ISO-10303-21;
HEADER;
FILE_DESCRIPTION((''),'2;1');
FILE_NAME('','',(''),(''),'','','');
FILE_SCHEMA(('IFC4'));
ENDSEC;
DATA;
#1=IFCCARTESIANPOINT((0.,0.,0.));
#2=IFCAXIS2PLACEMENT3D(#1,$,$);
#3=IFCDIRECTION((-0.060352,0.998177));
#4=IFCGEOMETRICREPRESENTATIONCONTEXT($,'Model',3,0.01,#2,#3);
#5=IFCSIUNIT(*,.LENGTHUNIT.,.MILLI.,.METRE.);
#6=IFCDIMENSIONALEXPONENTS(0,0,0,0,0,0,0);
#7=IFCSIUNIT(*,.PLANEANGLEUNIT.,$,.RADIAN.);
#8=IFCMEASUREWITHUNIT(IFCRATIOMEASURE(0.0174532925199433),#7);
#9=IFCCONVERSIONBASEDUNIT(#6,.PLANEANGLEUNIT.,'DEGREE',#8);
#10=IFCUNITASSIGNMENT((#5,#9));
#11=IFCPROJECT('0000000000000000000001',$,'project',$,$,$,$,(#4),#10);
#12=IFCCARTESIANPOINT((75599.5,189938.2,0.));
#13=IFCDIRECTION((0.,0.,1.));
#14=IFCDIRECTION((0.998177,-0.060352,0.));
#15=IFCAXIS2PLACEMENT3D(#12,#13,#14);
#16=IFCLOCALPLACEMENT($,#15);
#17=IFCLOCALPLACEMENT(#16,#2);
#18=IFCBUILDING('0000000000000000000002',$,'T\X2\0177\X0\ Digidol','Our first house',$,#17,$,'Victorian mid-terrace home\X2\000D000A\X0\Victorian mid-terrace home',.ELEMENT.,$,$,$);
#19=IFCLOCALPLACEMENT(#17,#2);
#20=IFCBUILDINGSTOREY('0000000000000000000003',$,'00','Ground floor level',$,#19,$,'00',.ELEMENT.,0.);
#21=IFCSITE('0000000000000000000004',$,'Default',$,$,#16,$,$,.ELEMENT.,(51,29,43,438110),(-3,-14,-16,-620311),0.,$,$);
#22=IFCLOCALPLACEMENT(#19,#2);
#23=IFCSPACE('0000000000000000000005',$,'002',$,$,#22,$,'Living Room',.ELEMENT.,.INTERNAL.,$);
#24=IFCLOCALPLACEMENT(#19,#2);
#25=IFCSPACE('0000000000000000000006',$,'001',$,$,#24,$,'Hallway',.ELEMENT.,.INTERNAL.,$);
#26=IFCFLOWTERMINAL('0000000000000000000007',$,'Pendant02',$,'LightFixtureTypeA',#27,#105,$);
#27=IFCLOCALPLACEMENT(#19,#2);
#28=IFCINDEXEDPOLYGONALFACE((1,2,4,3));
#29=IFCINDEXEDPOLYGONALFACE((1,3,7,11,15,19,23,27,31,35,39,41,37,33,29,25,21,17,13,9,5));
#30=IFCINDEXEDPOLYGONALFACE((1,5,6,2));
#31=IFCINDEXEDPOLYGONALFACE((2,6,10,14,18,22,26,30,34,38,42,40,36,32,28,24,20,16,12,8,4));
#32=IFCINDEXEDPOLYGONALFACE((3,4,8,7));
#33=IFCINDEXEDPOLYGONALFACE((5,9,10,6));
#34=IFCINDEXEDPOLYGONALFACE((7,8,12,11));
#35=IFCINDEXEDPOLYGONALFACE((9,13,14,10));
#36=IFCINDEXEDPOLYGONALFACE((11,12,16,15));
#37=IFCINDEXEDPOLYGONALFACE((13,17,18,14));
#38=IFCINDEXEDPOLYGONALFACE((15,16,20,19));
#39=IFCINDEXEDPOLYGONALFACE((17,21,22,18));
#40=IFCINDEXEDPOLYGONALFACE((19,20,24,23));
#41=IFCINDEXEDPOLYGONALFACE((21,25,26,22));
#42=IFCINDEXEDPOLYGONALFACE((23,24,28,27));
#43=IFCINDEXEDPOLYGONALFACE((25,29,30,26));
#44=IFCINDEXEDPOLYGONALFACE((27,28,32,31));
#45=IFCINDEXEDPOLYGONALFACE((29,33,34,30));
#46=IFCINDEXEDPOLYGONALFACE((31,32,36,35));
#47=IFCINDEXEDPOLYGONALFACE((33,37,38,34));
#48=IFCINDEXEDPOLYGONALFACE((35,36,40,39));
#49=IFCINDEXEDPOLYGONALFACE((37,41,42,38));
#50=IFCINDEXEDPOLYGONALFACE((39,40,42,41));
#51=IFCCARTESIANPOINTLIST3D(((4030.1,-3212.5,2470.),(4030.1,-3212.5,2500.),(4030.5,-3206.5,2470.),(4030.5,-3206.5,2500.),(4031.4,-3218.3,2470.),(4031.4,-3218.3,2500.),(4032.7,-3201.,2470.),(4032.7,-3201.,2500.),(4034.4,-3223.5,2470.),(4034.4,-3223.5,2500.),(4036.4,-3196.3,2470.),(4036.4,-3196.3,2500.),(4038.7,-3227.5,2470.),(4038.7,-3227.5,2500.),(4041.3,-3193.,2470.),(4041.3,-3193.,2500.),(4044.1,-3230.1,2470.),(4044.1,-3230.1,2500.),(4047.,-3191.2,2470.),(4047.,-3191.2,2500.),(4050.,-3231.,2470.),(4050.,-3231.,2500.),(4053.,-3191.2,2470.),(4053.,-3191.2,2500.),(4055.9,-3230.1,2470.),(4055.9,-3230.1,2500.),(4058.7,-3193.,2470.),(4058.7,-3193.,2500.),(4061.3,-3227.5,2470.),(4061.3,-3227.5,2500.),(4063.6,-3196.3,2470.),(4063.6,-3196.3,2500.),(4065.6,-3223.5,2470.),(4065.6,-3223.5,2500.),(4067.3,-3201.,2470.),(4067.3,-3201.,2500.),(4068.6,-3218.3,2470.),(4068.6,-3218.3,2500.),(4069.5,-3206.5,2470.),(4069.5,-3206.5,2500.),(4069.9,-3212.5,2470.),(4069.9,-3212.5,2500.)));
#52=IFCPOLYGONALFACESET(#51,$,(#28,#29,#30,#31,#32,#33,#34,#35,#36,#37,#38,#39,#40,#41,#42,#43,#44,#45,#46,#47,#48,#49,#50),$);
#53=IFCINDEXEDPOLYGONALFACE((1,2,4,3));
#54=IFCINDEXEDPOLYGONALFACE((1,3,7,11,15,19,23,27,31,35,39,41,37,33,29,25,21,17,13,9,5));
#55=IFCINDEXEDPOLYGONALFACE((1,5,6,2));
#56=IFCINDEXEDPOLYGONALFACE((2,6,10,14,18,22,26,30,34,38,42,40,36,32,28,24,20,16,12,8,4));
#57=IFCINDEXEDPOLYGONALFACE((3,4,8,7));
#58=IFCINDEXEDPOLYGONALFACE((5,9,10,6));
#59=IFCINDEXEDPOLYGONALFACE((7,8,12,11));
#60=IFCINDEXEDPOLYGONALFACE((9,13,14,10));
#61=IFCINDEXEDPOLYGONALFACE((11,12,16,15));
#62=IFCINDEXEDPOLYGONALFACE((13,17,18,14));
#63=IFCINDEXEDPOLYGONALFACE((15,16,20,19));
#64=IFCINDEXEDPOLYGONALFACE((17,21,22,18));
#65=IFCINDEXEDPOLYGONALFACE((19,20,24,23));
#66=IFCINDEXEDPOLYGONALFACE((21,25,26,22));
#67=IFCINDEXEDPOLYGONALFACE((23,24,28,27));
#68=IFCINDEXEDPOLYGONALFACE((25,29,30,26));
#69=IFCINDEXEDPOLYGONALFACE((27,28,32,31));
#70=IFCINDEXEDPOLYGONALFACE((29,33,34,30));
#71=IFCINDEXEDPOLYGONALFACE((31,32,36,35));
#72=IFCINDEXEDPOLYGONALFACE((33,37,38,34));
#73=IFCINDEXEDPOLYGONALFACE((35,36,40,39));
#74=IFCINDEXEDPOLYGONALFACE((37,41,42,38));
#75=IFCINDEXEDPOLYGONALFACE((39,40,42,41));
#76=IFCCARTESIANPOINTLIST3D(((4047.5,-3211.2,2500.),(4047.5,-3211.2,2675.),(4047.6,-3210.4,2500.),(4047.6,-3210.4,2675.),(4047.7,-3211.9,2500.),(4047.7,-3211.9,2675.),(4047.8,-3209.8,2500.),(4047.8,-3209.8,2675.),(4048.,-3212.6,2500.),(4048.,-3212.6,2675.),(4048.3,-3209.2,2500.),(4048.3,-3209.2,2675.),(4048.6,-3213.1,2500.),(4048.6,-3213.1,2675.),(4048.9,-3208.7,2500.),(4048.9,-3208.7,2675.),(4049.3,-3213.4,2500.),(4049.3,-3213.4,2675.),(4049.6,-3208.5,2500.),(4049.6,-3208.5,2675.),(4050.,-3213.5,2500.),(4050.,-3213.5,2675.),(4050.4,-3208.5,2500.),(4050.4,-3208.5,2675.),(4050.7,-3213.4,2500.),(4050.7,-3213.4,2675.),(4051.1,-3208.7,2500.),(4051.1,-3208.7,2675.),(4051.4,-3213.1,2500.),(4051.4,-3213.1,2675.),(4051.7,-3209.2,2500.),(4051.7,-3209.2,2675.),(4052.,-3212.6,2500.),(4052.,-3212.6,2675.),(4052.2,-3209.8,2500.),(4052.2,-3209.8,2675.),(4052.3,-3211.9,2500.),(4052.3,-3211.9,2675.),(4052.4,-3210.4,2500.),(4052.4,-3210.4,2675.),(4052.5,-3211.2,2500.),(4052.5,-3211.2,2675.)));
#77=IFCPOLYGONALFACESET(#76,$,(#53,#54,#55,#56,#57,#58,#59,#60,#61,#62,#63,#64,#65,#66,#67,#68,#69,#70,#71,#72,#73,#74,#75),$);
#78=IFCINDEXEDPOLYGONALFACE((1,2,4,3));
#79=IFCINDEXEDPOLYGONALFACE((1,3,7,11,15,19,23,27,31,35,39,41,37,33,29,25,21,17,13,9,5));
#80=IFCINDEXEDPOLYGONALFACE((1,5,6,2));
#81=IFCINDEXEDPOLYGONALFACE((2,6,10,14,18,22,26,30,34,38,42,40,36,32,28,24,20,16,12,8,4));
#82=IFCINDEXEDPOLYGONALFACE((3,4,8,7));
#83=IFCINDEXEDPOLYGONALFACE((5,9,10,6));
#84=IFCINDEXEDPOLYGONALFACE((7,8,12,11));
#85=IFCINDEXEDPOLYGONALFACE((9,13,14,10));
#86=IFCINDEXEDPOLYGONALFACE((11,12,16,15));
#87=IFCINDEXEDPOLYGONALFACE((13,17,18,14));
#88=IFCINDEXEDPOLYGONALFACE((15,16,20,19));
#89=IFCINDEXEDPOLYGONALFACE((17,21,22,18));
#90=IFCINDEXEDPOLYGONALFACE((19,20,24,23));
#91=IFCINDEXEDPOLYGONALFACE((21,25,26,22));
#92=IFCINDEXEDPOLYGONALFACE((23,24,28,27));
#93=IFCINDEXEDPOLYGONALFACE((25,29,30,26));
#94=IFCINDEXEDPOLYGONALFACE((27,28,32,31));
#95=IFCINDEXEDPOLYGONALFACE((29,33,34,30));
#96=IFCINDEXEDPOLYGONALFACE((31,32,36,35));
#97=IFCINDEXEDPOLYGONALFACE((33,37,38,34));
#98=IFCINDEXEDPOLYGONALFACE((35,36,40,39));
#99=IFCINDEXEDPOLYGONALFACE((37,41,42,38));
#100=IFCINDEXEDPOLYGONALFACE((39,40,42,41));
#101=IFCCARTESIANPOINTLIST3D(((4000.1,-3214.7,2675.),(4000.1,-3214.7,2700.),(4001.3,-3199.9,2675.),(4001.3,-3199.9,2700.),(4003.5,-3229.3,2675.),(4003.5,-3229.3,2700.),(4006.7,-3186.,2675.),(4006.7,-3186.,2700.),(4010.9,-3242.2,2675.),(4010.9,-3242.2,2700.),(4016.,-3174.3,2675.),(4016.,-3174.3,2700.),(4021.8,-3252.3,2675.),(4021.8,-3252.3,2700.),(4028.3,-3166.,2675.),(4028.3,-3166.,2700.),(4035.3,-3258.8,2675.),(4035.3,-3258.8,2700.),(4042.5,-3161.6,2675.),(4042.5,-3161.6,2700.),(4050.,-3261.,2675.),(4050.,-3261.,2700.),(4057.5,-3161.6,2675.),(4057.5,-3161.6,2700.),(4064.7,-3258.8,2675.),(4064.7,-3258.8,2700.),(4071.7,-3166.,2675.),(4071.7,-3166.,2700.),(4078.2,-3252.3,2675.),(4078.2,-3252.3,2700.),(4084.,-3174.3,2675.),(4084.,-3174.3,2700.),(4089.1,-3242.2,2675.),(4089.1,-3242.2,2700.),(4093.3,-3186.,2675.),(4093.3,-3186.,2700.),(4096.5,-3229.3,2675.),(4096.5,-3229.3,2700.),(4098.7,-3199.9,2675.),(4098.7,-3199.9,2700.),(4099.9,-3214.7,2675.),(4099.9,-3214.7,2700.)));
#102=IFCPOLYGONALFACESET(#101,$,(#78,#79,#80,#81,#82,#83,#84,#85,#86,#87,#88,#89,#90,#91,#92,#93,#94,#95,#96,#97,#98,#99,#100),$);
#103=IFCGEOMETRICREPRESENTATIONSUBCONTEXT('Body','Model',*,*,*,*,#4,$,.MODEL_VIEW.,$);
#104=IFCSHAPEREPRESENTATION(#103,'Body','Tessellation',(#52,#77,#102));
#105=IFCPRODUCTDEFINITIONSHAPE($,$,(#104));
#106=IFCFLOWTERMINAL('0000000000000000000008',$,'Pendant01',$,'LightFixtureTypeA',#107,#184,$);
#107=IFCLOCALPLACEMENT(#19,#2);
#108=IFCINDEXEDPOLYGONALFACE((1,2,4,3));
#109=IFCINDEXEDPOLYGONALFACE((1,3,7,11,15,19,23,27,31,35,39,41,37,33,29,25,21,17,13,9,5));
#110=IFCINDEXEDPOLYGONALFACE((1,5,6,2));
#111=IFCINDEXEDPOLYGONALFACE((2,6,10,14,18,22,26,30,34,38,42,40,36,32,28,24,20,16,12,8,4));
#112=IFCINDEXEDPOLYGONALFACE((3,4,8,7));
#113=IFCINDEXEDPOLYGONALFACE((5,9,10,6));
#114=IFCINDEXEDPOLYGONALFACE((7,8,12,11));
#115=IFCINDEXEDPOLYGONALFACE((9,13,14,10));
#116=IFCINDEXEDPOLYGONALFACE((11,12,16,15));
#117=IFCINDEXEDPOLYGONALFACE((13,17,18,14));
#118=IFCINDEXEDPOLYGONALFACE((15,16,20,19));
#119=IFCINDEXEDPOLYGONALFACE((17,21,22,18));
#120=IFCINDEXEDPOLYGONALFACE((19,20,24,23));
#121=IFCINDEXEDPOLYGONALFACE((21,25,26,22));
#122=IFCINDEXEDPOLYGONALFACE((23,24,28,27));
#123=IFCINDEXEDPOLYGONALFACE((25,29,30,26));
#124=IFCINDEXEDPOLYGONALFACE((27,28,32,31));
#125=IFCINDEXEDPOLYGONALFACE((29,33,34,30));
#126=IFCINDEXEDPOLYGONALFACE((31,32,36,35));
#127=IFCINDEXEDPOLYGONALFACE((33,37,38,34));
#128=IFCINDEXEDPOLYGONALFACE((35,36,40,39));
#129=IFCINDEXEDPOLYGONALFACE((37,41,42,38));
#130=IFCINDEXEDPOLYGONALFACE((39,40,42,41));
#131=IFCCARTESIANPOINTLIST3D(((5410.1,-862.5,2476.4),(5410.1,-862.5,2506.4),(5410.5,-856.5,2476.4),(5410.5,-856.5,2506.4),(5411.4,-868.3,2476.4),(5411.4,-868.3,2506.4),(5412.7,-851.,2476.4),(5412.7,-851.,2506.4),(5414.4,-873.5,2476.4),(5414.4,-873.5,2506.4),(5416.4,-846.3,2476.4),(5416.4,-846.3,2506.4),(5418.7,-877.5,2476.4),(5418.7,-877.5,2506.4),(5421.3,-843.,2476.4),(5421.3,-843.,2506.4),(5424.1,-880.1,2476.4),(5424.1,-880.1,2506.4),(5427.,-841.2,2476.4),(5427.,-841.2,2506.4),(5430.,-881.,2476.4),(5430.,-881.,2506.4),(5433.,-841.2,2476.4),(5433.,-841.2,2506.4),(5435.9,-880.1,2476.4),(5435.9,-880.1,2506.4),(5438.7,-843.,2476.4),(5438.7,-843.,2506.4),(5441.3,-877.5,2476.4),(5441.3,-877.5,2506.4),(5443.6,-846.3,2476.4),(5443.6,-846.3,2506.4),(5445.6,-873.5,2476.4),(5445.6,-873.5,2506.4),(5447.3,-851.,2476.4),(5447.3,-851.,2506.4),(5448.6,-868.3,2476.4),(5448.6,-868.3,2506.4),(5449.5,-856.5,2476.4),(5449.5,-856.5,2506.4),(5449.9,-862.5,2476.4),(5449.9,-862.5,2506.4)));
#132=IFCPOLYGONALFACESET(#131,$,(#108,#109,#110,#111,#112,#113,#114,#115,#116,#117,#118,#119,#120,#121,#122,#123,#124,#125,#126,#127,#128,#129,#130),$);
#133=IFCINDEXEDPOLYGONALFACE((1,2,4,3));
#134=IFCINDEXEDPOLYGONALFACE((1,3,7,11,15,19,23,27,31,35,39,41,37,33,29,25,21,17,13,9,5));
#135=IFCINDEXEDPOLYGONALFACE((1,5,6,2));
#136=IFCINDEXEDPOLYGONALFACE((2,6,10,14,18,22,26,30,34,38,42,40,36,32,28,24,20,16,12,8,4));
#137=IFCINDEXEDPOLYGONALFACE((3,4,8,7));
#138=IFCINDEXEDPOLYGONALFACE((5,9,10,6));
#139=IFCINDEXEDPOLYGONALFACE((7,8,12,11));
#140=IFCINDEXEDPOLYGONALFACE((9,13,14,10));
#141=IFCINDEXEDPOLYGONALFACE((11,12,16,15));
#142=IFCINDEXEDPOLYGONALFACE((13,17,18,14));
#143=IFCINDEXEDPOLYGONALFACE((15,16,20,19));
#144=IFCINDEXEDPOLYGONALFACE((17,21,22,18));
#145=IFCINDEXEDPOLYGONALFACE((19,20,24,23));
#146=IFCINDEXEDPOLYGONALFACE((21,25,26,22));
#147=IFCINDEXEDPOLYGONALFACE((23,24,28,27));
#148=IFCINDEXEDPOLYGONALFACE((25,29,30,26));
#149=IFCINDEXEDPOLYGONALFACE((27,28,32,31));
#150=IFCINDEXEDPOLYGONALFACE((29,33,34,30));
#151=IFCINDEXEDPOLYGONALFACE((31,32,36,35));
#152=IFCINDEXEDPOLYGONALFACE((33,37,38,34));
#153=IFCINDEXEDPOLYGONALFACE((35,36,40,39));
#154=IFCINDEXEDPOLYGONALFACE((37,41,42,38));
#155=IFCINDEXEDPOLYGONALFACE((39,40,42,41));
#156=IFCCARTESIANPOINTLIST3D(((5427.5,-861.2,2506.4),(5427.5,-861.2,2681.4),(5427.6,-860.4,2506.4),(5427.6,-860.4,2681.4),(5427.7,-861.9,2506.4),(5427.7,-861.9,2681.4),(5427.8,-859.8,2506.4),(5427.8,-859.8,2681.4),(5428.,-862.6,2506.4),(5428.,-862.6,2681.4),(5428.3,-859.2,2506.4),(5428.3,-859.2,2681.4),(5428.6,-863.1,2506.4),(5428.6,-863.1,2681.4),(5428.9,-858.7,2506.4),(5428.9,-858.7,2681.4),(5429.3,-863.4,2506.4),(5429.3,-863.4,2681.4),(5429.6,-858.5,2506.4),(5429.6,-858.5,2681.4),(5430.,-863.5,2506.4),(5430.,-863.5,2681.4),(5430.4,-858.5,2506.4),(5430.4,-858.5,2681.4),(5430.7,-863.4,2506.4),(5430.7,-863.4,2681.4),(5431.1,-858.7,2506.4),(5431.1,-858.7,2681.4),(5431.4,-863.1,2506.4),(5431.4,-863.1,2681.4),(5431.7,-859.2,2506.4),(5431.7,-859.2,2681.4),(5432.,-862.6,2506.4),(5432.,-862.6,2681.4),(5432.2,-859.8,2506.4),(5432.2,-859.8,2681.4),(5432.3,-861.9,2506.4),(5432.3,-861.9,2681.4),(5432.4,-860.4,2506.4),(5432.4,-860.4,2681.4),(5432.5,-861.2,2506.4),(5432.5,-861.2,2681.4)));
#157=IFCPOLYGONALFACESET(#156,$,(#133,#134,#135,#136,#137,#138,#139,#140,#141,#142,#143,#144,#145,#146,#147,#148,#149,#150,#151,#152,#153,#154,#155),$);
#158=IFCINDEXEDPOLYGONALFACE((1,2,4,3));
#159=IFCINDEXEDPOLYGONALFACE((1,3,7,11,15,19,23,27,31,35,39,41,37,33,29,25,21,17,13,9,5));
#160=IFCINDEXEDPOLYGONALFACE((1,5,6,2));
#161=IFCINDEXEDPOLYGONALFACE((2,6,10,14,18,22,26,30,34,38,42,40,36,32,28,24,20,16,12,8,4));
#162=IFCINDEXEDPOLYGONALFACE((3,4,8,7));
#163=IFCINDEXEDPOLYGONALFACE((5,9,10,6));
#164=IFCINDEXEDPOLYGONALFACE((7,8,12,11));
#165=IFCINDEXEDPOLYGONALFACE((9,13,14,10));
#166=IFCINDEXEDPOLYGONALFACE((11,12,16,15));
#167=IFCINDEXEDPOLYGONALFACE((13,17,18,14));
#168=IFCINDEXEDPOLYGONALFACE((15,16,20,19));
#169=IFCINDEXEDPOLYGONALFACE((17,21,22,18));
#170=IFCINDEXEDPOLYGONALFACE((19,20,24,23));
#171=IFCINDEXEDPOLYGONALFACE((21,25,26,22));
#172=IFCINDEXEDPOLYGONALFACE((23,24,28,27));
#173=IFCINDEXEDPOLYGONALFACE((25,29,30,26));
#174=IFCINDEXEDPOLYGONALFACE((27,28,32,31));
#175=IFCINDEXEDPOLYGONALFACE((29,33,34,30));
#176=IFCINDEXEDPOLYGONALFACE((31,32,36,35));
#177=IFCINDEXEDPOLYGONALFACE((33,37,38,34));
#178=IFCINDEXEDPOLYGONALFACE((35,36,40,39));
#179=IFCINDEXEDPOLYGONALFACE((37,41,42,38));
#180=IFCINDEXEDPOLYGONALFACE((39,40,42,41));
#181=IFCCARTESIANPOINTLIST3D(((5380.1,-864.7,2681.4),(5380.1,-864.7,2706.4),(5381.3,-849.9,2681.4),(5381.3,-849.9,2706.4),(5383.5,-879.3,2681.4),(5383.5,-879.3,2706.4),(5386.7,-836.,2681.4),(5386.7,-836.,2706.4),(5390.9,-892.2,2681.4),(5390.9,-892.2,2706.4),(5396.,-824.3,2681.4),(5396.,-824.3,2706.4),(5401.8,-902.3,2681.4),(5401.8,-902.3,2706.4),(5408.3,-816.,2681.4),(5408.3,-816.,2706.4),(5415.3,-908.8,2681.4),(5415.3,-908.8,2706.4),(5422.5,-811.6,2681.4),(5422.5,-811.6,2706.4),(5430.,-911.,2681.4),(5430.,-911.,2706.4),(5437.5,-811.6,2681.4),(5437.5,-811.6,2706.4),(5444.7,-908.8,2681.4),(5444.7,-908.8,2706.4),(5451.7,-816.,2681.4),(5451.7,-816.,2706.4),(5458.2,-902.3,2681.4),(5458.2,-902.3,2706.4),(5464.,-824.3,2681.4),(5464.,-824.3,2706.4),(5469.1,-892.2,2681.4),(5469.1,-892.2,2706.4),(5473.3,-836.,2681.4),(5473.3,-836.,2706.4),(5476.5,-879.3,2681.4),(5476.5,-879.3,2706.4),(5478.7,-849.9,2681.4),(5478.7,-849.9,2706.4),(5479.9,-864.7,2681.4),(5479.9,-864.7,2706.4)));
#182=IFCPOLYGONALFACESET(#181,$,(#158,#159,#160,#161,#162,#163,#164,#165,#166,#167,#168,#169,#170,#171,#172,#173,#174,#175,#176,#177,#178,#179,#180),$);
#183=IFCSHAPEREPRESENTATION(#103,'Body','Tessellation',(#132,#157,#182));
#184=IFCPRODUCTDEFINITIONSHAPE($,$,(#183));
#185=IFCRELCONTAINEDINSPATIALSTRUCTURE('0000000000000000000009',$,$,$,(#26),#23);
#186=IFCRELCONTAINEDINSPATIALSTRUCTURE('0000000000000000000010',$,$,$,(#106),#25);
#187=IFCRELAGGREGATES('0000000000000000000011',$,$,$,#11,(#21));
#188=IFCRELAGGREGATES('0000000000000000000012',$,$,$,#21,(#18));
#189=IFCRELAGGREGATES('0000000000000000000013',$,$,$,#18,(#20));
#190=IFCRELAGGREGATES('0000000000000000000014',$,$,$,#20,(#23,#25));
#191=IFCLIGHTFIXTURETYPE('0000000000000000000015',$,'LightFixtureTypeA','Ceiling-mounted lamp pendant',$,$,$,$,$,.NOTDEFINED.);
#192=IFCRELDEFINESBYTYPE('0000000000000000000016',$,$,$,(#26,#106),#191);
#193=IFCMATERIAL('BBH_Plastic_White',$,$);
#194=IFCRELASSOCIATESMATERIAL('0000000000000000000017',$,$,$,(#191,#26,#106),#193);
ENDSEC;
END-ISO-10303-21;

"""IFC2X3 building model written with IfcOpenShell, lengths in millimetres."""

from ifc_helpers import new_model, entity, si_unit, converted_unit, direction, frame, frame_2d, origin, place, context, subcontext, project, spatial, circle, extrude, source, transform, mapped, material, type_object, type_shapes, element, save


model = new_model("IFC2X3")

# Units and contexts
model_context = context("Model", 3, precision=0.01, world=origin(), true_north=direction((-0.060352, 0.998177)))
body_context = subcontext(model_context, "Body", "Model", "MODEL_VIEW")
ifc_project = project(units=[si_unit("LENGTHUNIT", "METRE", prefix="MILLI"), converted_unit("PLANEANGLEUNIT", "DEGREE", entity("IfcRatioMeasure", 0.0174532925199433), si_unit("PLANEANGLEUNIT", "RADIAN"), dimensions=[0, 0, 0, 0, 0, 0, 0])], contexts=[model_context])

# Site, building, storey
site_placement = place(None, frame((75599.5, 189938.2, 0.0), z_axis=(0.0, 0.0, 1.0), x_axis=(0.998177, -0.060352, 0.0)))
site = spatial("IfcSite", under=ifc_project, at=site_placement, Name="Default", CompositionType="ELEMENT", RefLatitude=(51, 29, 43, 438110), RefLongitude=(-3, -14, -16, -620311), RefElevation=0.0)
building_placement = place(site_placement, origin())
building = spatial("IfcBuilding", under=site, at=building_placement, Name="Tŷ Digidol", Description="Our first house", LongName="Victorian mid-terrace home\r\nVictorian mid-terrace home", CompositionType="ELEMENT")
storey_placement = place(building_placement, origin())
storey = spatial("IfcBuildingStorey", under=building, at=storey_placement, Name="00", Description="Ground floor level", LongName="00", CompositionType="ELEMENT", Elevation=0.0)

# Shared definitions
space_1_placement = place(storey_placement, origin())
space_1 = spatial("IfcSpace", under=storey, at=space_1_placement, Name="002", LongName="Living Room", CompositionType="ELEMENT", InteriorOrExteriorSpace="INTERNAL")

# Flow terminal
ifc_material_1 = material(Name="BBH_Plastic_White")
light_fixture_type_1 = type_object("IfcLightFixtureType", Name="LightFixtureTypeA", Description="Ceiling-mounted lamp pendant", PredefinedType="NOTDEFINED", material=ifc_material_1)
shared_shape_1 = source(origin(), body_context, "Body", "SweptSolid", [
    extrude(circle(Radius=20.0, at=frame_2d((0.0, 0.0), x_axis=(1.0, 0.0))), frame((0.0, 0.0, 200.0)), (0.0, 0.0, 1.0), 30.0),
    extrude(circle(Radius=2.5, at=frame_2d((0.0, 0.0), x_axis=(1.0, 0.0))), frame((0.0, 0.0, 25.0)), (0.0, 0.0, 1.0), 175.0),
    extrude(circle(Radius=50.0, at=frame_2d((0.0, 0.0), x_axis=(1.0, 0.0))), origin(), (0.0, 0.0, 1.0), 25.0),
])
type_shapes(light_fixture_type_1, [shared_shape_1])
flow_terminal_1_placement = place(space_1_placement, frame((4050.0, -3211.0, 2700.0), z_axis=(0.0, 0.0, -1.0), x_axis=(0.0, -1.0, 0.0)))
element("IfcFlowTerminal", 1, at=flow_terminal_1_placement, inside=space_1, type_object=light_fixture_type_1, material=ifc_material_1, Name="Pendant02", ObjectType="LightFixtureTypeA", context=body_context, shape_type="MappedRepresentation", body=[
    mapped(shared_shape_1, transform((0.0, 0.0, 0.0), scale=1.0)),
])

# Shared definitions
space_2_placement = place(storey_placement, origin())
space_2 = spatial("IfcSpace", under=storey, at=space_2_placement, Name="001", LongName="Hallway", CompositionType="ELEMENT", InteriorOrExteriorSpace="INTERNAL")

# Flow terminal
flow_terminal_2_placement = place(space_2_placement, frame((5430.0, -861.0, 2706.3), z_axis=(0.0, 0.0, -1.0), x_axis=(0.0, -1.0, 0.0)))
element("IfcFlowTerminal", 2, at=flow_terminal_2_placement, inside=space_2, type_object=light_fixture_type_1, material=ifc_material_1, Name="Pendant01", ObjectType="LightFixtureTypeA", context=body_context, shape_type="MappedRepresentation", body=[
    mapped(shared_shape_1, transform((0.0, 0.0, 0.0), scale=1.0)),
])

save(model, "model.ifc")
